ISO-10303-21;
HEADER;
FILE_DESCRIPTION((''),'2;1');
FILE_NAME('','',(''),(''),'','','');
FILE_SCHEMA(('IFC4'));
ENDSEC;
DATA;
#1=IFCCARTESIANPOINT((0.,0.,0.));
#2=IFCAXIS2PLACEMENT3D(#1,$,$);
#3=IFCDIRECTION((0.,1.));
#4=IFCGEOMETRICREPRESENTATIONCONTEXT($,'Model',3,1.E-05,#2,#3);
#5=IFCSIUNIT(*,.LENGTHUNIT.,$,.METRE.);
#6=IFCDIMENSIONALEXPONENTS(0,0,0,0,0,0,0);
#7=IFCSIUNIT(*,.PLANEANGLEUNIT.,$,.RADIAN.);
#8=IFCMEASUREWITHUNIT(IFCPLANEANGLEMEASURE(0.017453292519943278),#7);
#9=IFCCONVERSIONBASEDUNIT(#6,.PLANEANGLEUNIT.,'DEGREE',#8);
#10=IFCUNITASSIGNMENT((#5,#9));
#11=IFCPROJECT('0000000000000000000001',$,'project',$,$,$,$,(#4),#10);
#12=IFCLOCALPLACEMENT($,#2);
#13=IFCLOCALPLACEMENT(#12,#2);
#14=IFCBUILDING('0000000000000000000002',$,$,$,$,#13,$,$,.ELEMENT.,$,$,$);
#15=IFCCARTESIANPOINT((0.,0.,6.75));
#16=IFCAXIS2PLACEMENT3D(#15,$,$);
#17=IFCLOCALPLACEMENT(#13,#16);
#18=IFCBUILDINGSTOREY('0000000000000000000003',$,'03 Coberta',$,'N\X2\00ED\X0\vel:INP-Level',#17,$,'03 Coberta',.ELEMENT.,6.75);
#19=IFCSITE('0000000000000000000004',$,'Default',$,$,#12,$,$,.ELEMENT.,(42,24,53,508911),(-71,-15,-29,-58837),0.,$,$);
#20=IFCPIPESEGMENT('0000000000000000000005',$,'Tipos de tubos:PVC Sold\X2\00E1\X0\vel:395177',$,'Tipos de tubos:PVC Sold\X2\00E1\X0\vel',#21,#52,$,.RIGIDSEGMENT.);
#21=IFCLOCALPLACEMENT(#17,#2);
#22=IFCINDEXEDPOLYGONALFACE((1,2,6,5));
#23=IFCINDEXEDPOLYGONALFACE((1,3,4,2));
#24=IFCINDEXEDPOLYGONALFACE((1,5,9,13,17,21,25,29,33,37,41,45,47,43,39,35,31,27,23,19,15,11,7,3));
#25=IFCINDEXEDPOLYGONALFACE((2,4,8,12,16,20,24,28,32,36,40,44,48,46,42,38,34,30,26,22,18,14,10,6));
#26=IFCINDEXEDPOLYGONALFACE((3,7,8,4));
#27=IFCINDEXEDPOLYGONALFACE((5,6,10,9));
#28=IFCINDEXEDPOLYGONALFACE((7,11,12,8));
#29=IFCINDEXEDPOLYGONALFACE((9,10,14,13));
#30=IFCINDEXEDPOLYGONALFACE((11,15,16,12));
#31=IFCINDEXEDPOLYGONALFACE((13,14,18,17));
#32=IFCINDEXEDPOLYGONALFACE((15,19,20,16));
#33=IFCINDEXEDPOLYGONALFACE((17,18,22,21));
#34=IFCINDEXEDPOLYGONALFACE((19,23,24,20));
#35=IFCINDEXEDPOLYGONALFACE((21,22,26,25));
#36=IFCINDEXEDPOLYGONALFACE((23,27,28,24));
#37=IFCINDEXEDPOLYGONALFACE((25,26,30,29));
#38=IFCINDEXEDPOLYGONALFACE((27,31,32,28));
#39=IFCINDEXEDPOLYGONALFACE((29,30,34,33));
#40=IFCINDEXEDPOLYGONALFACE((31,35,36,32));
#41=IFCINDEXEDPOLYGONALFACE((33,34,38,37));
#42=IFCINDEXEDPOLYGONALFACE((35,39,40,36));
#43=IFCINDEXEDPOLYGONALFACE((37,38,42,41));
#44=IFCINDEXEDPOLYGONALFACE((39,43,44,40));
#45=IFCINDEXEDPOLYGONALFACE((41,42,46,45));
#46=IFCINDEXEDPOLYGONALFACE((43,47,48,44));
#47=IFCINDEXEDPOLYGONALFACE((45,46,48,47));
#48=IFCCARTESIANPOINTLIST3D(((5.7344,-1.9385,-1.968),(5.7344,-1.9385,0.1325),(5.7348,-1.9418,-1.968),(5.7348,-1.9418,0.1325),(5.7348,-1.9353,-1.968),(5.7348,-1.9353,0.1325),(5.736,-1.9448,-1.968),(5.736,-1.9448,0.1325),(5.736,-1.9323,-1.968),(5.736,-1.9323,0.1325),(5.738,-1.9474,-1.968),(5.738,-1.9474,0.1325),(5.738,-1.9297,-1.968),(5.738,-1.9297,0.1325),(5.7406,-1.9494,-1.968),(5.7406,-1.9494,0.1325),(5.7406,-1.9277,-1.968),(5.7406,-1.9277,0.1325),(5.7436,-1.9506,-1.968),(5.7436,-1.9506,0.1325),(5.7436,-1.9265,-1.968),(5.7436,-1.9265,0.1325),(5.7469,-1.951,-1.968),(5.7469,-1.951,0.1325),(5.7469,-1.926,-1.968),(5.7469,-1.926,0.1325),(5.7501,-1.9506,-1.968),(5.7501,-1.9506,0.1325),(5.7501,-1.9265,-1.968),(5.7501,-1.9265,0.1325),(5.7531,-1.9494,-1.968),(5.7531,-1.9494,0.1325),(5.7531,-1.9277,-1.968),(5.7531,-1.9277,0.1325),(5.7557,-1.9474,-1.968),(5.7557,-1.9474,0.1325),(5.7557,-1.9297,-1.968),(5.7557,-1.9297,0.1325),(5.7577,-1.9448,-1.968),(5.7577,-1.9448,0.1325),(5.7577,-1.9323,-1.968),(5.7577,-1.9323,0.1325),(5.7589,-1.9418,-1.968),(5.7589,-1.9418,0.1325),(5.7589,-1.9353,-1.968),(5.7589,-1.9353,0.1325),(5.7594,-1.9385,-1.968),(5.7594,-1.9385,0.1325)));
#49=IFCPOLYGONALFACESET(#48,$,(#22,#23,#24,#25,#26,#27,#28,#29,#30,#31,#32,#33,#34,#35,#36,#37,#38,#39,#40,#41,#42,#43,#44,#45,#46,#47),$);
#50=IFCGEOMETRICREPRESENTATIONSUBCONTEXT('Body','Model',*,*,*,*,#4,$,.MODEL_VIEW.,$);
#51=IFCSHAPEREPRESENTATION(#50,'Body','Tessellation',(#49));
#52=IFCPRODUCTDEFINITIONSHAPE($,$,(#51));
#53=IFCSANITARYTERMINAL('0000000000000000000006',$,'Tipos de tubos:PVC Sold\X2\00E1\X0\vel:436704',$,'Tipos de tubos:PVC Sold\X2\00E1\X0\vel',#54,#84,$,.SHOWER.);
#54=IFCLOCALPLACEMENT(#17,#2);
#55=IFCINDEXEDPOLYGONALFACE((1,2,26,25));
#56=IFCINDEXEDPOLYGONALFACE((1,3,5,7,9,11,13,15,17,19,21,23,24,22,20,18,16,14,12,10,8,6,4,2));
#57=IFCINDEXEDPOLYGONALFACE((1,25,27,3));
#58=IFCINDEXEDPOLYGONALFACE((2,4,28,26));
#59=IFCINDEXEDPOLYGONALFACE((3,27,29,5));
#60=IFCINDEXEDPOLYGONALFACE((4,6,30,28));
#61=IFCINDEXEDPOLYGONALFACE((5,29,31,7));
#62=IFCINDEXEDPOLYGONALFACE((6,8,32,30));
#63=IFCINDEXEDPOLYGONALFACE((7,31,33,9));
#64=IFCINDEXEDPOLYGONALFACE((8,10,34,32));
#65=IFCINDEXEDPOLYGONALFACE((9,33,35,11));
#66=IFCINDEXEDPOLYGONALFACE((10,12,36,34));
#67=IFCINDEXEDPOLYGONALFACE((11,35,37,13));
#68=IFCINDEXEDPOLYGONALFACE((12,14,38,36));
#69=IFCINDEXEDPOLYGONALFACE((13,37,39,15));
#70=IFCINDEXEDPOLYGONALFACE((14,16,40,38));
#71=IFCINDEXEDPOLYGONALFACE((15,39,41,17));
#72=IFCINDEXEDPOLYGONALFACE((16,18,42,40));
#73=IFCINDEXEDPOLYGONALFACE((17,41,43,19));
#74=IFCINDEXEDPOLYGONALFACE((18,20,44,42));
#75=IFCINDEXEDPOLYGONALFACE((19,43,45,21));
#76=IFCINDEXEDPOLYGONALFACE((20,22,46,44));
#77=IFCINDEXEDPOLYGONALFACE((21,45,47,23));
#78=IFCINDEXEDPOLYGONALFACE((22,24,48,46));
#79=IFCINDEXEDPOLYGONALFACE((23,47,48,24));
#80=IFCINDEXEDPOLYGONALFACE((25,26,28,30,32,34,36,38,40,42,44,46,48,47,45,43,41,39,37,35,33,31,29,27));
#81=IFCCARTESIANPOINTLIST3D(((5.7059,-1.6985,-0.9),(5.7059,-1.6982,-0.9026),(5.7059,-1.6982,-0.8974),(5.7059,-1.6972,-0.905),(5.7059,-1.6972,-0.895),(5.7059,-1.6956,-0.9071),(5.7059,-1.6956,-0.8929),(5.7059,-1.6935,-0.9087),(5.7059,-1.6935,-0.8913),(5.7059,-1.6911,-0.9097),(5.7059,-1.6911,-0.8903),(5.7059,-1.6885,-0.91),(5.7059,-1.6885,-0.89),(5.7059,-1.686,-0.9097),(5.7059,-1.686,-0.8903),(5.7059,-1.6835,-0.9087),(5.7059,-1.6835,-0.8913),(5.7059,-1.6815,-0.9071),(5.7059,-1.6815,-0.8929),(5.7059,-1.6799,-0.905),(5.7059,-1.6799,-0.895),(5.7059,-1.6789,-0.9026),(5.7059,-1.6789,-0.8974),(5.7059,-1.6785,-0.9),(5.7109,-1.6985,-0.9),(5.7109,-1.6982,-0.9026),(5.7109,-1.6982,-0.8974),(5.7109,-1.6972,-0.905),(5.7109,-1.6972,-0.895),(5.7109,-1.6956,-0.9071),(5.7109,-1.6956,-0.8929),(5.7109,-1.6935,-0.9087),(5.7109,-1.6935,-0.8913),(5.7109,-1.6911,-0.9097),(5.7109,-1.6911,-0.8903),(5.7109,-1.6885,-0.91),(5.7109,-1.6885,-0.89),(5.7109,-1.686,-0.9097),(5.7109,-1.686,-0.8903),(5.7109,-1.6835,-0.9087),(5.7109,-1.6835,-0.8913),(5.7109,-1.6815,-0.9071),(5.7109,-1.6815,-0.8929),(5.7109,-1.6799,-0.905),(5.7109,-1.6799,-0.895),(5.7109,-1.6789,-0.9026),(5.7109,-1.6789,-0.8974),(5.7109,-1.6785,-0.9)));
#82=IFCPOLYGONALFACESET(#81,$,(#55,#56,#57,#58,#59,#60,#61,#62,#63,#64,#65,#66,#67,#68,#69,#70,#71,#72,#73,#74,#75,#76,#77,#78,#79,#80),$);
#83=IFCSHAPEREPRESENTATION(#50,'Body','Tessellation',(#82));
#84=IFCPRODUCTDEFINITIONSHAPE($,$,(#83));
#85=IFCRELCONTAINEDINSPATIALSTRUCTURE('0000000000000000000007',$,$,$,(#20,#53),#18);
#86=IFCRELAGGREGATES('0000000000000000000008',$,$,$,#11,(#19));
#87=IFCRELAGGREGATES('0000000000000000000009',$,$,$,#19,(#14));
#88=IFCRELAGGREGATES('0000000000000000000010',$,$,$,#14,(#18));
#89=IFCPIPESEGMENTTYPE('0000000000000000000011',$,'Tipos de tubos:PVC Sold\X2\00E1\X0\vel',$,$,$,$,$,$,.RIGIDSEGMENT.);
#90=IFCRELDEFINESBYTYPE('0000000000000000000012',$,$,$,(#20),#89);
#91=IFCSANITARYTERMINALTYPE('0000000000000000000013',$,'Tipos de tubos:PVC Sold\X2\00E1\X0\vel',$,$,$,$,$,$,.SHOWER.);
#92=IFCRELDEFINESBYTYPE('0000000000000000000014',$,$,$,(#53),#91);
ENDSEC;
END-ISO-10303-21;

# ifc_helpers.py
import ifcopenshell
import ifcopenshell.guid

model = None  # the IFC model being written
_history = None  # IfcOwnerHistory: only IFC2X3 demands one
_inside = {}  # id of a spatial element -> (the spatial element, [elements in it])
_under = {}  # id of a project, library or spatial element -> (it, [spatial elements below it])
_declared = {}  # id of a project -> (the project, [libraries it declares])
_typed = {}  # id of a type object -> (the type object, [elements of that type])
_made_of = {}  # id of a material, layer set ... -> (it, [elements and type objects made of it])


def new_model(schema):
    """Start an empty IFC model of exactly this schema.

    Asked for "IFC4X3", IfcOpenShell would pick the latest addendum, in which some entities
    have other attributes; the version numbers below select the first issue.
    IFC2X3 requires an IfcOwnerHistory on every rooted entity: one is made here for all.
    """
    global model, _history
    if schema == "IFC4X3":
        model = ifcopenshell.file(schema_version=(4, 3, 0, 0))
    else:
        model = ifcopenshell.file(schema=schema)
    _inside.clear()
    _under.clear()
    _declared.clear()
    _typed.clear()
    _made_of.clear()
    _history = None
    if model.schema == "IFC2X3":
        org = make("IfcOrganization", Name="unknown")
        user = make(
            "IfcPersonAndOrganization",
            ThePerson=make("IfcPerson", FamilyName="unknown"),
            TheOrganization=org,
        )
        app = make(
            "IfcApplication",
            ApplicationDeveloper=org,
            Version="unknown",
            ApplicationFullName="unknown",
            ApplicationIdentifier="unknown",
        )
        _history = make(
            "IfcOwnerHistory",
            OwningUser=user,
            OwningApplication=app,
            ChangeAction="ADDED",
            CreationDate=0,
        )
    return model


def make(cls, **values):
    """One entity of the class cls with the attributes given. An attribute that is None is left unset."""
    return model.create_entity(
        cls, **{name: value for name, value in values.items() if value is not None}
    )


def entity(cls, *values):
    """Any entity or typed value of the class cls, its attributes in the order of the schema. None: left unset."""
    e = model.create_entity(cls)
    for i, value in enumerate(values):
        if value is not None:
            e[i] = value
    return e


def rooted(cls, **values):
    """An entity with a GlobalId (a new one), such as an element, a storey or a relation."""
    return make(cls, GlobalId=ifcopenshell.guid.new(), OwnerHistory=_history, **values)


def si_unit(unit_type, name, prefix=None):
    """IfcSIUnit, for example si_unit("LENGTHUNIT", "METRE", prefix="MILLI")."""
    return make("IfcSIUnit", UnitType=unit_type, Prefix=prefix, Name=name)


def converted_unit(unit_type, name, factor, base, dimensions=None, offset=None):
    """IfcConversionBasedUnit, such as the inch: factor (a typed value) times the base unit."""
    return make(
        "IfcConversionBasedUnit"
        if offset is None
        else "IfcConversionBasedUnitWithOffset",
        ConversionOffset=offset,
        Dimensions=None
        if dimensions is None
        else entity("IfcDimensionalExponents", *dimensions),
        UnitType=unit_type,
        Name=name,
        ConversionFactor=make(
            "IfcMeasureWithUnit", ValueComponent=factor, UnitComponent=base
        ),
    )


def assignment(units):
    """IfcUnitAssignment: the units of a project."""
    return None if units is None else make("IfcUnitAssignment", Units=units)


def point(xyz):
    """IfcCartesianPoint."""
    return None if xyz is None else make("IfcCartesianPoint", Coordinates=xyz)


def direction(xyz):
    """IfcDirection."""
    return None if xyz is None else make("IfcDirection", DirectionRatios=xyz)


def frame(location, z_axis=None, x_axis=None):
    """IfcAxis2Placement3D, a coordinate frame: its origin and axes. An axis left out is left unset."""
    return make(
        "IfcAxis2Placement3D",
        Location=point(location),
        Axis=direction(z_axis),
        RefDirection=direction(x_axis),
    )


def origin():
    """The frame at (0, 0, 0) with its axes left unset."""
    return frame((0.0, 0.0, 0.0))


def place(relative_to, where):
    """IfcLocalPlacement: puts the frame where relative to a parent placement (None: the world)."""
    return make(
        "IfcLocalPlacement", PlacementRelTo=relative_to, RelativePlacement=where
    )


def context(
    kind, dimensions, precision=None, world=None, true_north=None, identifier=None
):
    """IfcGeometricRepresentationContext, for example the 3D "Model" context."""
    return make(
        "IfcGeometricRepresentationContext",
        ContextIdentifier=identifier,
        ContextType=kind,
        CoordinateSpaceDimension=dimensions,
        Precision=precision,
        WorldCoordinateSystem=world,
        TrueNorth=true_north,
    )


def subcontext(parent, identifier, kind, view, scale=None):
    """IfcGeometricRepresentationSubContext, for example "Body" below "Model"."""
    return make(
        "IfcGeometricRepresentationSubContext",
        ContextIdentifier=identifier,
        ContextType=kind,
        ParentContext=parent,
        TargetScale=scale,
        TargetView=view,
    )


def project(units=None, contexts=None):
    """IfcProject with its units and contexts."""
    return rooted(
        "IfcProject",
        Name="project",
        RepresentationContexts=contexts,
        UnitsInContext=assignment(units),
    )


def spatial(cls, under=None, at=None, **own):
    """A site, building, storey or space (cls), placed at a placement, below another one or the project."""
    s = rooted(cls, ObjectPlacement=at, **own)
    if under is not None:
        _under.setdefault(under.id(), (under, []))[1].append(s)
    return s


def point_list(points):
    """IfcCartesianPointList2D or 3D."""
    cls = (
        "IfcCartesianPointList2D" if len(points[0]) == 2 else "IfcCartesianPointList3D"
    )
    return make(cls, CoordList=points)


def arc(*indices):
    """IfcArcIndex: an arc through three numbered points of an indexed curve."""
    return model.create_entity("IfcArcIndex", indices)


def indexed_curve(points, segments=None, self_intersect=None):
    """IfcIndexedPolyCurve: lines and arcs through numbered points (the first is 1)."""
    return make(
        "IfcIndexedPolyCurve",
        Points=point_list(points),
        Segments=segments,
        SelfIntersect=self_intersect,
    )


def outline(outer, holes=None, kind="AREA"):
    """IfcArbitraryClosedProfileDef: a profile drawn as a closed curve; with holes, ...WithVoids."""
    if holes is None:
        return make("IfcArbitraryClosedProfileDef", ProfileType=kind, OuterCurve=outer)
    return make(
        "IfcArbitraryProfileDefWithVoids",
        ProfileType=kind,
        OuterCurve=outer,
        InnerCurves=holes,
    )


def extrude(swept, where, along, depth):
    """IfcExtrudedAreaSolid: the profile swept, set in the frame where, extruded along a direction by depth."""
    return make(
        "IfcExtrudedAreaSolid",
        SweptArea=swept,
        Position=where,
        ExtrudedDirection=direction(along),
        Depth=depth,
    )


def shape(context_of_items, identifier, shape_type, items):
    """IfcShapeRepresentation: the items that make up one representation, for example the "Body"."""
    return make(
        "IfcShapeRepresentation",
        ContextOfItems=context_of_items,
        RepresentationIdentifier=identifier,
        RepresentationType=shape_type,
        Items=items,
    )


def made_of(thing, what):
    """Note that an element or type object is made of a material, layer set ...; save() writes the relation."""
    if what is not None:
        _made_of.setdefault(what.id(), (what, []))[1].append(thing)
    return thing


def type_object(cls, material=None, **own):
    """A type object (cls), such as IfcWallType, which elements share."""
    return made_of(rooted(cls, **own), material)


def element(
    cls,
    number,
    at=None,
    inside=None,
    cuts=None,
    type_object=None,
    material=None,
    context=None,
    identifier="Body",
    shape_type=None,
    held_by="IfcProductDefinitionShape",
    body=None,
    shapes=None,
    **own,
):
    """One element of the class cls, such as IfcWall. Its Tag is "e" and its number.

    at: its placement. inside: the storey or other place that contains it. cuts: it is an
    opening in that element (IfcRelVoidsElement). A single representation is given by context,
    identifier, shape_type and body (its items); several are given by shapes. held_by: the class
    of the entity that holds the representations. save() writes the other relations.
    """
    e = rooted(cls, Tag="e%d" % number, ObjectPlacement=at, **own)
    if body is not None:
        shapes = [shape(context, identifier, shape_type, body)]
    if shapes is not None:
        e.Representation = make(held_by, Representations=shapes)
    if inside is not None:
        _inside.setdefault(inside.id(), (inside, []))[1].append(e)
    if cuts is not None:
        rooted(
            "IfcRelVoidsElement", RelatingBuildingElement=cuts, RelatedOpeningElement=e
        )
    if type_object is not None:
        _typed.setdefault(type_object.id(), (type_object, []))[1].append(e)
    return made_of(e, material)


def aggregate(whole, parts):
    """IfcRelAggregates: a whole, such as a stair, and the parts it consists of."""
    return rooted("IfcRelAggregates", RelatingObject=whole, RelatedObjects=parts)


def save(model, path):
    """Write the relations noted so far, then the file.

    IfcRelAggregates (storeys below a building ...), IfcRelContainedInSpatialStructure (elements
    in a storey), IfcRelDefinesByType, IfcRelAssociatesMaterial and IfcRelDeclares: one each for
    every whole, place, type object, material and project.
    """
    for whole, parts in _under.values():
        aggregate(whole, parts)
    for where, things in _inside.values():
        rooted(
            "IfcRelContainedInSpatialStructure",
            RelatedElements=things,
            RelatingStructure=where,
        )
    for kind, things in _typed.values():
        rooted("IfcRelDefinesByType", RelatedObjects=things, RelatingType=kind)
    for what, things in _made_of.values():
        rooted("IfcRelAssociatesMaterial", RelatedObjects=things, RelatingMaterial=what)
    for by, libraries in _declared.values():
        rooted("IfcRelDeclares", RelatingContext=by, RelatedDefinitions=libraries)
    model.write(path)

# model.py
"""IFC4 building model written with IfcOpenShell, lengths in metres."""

from ifc_helpers import new_model, entity, si_unit, converted_unit, direction, frame, origin, place, context, subcontext, project, spatial, arc, indexed_curve, outline, extrude, type_object, element, save


model = new_model("IFC4")

# Units and contexts
model_context = context("Model", 3, precision=1e-05, world=origin(), true_north=direction((0.0, 1.0)))
body_context = subcontext(model_context, "Body", "Model", "MODEL_VIEW")
ifc_project = project(units=[si_unit("LENGTHUNIT", "METRE"), converted_unit("PLANEANGLEUNIT", "DEGREE", entity("IfcPlaneAngleMeasure", 0.017453292519943278), si_unit("PLANEANGLEUNIT", "RADIAN"), dimensions=[0, 0, 0, 0, 0, 0, 0])], contexts=[model_context])

# Site, building, storey
site_placement = place(None, origin())
site = spatial("IfcSite", under=ifc_project, at=site_placement, Name="Default", CompositionType="ELEMENT", RefLatitude=(42, 24, 53, 508911), RefLongitude=(-71, -15, -29, -58837), RefElevation=0.0)
building_placement = place(site_placement, origin())
building = spatial("IfcBuilding", under=site, at=building_placement, CompositionType="ELEMENT")
storey_placement = place(building_placement, frame((0.0, 0.0, 6.75)))
storey = spatial("IfcBuildingStorey", under=building, at=storey_placement, Name="03 Coberta", ObjectType="Nível:INP-Level", LongName="03 Coberta", CompositionType="ELEMENT", Elevation=6.75)

# Pipe segment
pipe_segment_type = type_object("IfcPipeSegmentType", Name="Tipos de tubos:PVC Soldável", PredefinedType="RIGIDSEGMENT")
pipe_segment_1_placement = place(storey_placement, origin())
element("IfcPipeSegment", 1, at=pipe_segment_1_placement, inside=storey, type_object=pipe_segment_type, Name="Tipos de tubos:PVC Soldável:395177", ObjectType="Tipos de tubos:PVC Soldável", PredefinedType="RIGIDSEGMENT", context=body_context, shape_type="SweptSolid", body=[
    extrude(outline(indexed_curve([(0.0125, 0.0), (0.0088, 0.0088), (0.0, 0.0125), (-0.0088, 0.0088), (-0.0125, 0.0), (-0.0088, -0.0088), (0.0, -0.0125), (0.0088, -0.0088)], segments=[arc(1, 2, 3), arc(3, 4, 5), arc(5, 6, 7), arc(7, 8, 1)], self_intersect=False)), frame((5.7469, -1.9385, -1.968)), (0.0, 0.0, 1.0), 2.1005),
])

# Sanitary terminal
sanitary_terminal_type = type_object("IfcSanitaryTerminalType", Name="Tipos de tubos:PVC Soldável", PredefinedType="SHOWER")
sanitary_terminal_placement = place(storey_placement, origin())
element("IfcSanitaryTerminal", 2, at=sanitary_terminal_placement, inside=storey, type_object=sanitary_terminal_type, Name="Tipos de tubos:PVC Soldável:436704", ObjectType="Tipos de tubos:PVC Soldável", PredefinedType="SHOWER", context=body_context, shape_type="SweptSolid", body=[
    extrude(outline(indexed_curve([(0.01, 0.0), (0.0071, 0.0071), (0.0, 0.01), (-0.0071, 0.0071), (-0.01, 0.0), (-0.0071, -0.0071), (0.0, -0.01), (0.0071, -0.0071)], segments=[arc(1, 2, 3), arc(3, 4, 5), arc(5, 6, 7), arc(7, 8, 1)], self_intersect=False)), frame((5.7059, -1.6885, -0.9), z_axis=(1.0, 0.0, 0.0), x_axis=(0.0, 1.0, 0.0)), (0.0, 0.0, 1.0), 0.005),
])

save(model, "model.ifc")
